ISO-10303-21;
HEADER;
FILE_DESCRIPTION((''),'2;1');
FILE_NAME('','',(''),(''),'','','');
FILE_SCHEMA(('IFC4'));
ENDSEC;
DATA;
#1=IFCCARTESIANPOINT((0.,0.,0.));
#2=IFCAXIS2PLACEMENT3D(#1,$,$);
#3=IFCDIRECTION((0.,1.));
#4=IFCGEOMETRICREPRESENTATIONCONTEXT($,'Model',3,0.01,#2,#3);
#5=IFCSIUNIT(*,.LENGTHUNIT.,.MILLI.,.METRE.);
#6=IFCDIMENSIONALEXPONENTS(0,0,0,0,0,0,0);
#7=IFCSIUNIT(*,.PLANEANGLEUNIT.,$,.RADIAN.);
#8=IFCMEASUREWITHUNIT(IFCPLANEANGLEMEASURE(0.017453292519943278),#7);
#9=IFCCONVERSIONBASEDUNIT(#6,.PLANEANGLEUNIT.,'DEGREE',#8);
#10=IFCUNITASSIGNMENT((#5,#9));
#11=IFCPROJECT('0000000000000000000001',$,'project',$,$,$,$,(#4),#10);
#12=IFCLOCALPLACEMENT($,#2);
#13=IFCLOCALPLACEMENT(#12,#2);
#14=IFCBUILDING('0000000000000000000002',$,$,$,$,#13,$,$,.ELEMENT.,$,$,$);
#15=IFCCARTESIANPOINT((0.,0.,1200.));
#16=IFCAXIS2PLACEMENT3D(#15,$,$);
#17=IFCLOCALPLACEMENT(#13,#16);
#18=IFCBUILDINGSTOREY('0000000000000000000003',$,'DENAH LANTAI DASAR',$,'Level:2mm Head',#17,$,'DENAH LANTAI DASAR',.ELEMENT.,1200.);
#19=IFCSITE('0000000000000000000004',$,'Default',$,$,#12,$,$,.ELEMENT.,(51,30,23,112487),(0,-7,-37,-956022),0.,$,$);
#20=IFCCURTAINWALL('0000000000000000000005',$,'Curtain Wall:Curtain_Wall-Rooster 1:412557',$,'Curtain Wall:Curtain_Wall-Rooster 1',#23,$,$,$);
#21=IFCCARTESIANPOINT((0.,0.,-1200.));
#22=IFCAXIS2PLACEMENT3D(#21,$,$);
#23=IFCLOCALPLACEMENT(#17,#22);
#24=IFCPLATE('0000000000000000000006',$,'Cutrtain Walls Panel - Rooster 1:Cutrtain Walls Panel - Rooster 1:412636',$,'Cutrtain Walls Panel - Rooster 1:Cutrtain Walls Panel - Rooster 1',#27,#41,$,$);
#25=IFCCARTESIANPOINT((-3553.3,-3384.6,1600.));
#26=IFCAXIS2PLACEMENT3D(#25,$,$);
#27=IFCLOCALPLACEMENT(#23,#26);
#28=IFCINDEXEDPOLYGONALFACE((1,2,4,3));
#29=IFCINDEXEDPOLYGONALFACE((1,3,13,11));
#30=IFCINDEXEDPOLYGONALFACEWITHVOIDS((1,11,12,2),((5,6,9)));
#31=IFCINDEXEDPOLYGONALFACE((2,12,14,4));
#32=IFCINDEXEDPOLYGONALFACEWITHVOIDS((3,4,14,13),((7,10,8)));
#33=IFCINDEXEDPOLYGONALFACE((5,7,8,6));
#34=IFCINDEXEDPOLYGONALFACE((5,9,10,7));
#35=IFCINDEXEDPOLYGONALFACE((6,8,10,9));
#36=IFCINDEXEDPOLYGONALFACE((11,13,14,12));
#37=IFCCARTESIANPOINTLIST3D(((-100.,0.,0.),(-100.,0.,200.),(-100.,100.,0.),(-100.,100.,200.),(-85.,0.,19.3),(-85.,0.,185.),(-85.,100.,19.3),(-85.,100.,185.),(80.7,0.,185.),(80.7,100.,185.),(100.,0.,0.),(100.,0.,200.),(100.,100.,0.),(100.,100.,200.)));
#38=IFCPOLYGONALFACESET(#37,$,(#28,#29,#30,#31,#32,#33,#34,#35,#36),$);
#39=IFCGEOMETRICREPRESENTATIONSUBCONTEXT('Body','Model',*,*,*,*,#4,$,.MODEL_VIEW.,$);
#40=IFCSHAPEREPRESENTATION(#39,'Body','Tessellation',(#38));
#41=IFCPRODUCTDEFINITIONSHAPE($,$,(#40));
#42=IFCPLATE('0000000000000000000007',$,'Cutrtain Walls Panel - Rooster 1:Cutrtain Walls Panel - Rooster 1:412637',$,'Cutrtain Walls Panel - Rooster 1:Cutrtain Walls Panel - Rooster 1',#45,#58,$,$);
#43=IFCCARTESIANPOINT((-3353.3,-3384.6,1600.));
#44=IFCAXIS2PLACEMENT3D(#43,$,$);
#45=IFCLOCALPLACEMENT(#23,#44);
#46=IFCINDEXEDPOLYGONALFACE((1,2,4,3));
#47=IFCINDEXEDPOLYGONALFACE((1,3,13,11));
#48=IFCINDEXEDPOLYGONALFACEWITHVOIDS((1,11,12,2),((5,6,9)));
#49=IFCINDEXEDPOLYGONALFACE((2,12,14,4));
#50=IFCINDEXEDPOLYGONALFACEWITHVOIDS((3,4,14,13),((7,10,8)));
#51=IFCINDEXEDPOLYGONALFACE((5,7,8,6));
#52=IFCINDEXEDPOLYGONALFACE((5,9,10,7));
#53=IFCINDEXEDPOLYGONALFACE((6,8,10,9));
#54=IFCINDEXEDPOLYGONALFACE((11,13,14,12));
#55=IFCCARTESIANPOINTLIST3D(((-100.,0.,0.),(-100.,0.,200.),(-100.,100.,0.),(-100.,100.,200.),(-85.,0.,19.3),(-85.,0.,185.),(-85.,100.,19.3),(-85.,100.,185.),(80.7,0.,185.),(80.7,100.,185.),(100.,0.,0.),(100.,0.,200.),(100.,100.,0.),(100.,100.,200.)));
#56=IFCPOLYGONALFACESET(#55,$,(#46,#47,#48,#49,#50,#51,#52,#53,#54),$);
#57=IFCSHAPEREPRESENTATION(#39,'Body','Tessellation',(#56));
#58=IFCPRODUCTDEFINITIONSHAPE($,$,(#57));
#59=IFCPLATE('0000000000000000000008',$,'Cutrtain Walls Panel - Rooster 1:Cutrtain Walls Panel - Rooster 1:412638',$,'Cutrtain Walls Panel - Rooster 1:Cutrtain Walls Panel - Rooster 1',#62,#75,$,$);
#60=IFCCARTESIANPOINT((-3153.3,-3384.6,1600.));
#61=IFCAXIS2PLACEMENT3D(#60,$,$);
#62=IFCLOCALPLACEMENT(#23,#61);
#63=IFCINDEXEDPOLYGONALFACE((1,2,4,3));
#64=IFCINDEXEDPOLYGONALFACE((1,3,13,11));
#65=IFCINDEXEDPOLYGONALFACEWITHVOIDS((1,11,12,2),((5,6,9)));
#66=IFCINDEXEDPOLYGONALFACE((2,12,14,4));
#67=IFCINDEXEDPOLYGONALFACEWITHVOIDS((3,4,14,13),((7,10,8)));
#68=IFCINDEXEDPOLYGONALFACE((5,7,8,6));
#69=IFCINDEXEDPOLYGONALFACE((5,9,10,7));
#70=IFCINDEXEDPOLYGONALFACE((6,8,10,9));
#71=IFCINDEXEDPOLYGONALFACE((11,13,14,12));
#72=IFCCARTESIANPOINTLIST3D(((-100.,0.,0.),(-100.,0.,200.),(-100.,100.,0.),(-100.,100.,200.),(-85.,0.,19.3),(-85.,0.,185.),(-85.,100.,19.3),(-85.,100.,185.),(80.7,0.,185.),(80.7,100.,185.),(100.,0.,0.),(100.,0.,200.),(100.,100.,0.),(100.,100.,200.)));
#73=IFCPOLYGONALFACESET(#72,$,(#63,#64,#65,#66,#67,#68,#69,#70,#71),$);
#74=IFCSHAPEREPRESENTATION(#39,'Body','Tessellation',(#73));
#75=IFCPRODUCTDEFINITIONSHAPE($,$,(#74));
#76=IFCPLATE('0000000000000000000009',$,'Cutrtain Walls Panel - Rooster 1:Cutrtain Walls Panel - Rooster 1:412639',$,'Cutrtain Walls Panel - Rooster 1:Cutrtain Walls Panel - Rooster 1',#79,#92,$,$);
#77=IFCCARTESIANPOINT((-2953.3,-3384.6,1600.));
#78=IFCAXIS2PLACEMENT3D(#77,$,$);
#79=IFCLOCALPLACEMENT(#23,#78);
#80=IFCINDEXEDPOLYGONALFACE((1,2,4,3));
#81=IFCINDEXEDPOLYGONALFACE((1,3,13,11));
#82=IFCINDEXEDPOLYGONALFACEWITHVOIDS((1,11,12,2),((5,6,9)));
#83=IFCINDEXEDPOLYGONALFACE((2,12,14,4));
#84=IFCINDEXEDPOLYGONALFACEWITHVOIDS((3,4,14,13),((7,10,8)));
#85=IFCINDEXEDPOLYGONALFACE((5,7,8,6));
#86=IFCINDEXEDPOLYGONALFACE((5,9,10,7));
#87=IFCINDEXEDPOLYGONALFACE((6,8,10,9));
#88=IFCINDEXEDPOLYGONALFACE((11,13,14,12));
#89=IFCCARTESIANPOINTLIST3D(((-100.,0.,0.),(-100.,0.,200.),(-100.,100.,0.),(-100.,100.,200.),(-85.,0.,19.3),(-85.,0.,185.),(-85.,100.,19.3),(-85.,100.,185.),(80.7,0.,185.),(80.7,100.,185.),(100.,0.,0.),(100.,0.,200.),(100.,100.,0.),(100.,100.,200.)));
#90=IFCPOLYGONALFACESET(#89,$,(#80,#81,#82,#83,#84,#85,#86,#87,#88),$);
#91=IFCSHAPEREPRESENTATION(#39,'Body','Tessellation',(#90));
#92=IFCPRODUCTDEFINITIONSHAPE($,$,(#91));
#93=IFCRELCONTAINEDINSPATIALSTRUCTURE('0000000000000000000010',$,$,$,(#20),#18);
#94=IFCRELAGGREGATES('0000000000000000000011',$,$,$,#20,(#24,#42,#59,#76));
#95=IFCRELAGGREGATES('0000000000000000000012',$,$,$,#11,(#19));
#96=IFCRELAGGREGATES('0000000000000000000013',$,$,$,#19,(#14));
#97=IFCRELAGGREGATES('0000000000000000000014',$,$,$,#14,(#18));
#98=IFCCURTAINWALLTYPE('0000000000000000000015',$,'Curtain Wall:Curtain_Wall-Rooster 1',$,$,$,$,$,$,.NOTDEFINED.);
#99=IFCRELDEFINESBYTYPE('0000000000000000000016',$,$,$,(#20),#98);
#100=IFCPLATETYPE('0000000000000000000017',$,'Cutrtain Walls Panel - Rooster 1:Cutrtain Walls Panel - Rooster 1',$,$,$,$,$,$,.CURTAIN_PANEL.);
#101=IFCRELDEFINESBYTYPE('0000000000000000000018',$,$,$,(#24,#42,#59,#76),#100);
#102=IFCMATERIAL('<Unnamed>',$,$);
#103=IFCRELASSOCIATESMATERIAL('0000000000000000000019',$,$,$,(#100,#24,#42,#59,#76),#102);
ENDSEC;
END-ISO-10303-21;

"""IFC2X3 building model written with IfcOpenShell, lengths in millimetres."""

from ifc_helpers import new_model, entity, si_unit, converted_unit, direction, frame, origin, place, context, subcontext, project, spatial, polyline, outline, extrude, source, transform, mapped, material, type_object, type_shapes, element, aggregate, save


model = new_model("IFC2X3")

# Units and contexts
model_context = context("Model", 3, precision=0.01, world=origin(), true_north=direction((0.0, 1.0)))
body_context = subcontext(model_context, "Body", "Model", "MODEL_VIEW")
ifc_project = project(units=[si_unit("LENGTHUNIT", "METRE", prefix="MILLI"), converted_unit("PLANEANGLEUNIT", "DEGREE", entity("IfcPlaneAngleMeasure", 0.017453292519943278), si_unit("PLANEANGLEUNIT", "RADIAN"), dimensions=[0, 0, 0, 0, 0, 0, 0])], contexts=[model_context])

# Site, building, storey
site_placement = place(None, origin())
site = spatial("IfcSite", under=ifc_project, at=site_placement, Name="Default", CompositionType="ELEMENT", RefLatitude=(51, 30, 23, 112487), RefLongitude=(0, -7, -37, -956022), RefElevation=0.0)
building_placement = place(site_placement, origin())
building = spatial("IfcBuilding", under=site, at=building_placement, CompositionType="ELEMENT")
storey_placement = place(building_placement, frame((0.0, 0.0, 1200.0)))
storey = spatial("IfcBuildingStorey", under=building, at=storey_placement, Name="DENAH LANTAI DASAR", ObjectType="Level:2mm Head", LongName="DENAH LANTAI DASAR", CompositionType="ELEMENT", Elevation=1200.0)

# Curtain wall, plates
curtain_wall_type = type_object("IfcCurtainWallType", Name="Curtain Wall:Curtain_Wall-Rooster 1", PredefinedType="NOTDEFINED")
curtain_wall_placement = place(storey_placement, frame((0.0, 0.0, -1200.0)))
curtain_wall = element("IfcCurtainWall", 1, at=curtain_wall_placement, inside=storey, type_object=curtain_wall_type, Name="Curtain Wall:Curtain_Wall-Rooster 1:412557", ObjectType="Curtain Wall:Curtain_Wall-Rooster 1")
ifc_material = material(Name="<Unnamed>")
plate_type = type_object("IfcPlateType", Name="Cutrtain Walls Panel - Rooster 1:Cutrtain Walls Panel - Rooster 1", PredefinedType="CURTAIN_PANEL", material=ifc_material)
shared_shape = source(origin(), body_context, "Body", "SweptSolid", [
    extrude(outline(polyline([(-100.0, -100.0), (100.0, -100.0), (100.0, 100.0), (-100.0, 100.0), (-100.0, -100.0)]), holes=[polyline([(80.7, 85.0), (-85.0, -80.7), (-85.0, 85.0), (80.7, 85.0)])]), frame((0.0, 0.0, 100.0), z_axis=(0.0, 1.0, 0.0), x_axis=(0.0, 0.0, -1.0)), (0.0, 0.0, 1.0), 100.0),
])
type_shapes(plate_type, [shared_shape])
plate_1_placement = place(curtain_wall_placement, frame((-3553.3, -3384.6, 1600.0)))
plate_1 = element("IfcPlate", 2, at=plate_1_placement, type_object=plate_type, material=ifc_material, Name="Cutrtain Walls Panel - Rooster 1:Cutrtain Walls Panel - Rooster 1:412636", ObjectType="Cutrtain Walls Panel - Rooster 1:Cutrtain Walls Panel - Rooster 1", context=body_context, shape_type="MappedRepresentation", body=[
    mapped(shared_shape, transform((0.0, 0.0, 0.0), scale=1.0)),
])
plate_2_placement = place(curtain_wall_placement, frame((-3353.3, -3384.6, 1600.0)))
plate_2 = element("IfcPlate", 3, at=plate_2_placement, type_object=plate_type, material=ifc_material, Name="Cutrtain Walls Panel - Rooster 1:Cutrtain Walls Panel - Rooster 1:412637", ObjectType="Cutrtain Walls Panel - Rooster 1:Cutrtain Walls Panel - Rooster 1", context=body_context, shape_type="MappedRepresentation", body=[
    mapped(shared_shape, transform((0.0, 0.0, 0.0), scale=1.0)),
])
plate_3_placement = place(curtain_wall_placement, frame((-3153.3, -3384.6, 1600.0)))
plate_3 = element("IfcPlate", 4, at=plate_3_placement, type_object=plate_type, material=ifc_material, Name="Cutrtain Walls Panel - Rooster 1:Cutrtain Walls Panel - Rooster 1:412638", ObjectType="Cutrtain Walls Panel - Rooster 1:Cutrtain Walls Panel - Rooster 1", context=body_context, shape_type="MappedRepresentation", body=[
    mapped(shared_shape, transform((0.0, 0.0, 0.0), scale=1.0)),
])
plate_4_placement = place(curtain_wall_placement, frame((-2953.3, -3384.6, 1600.0)))
plate_4 = element("IfcPlate", 5, at=plate_4_placement, type_object=plate_type, material=ifc_material, Name="Cutrtain Walls Panel - Rooster 1:Cutrtain Walls Panel - Rooster 1:412639", ObjectType="Cutrtain Walls Panel - Rooster 1:Cutrtain Walls Panel - Rooster 1", context=body_context, shape_type="MappedRepresentation", body=[
    mapped(shared_shape, transform((0.0, 0.0, 0.0), scale=1.0)),
])
aggregate(curtain_wall, [plate_1, plate_2, plate_3, plate_4])

save(model, "model.ifc")
